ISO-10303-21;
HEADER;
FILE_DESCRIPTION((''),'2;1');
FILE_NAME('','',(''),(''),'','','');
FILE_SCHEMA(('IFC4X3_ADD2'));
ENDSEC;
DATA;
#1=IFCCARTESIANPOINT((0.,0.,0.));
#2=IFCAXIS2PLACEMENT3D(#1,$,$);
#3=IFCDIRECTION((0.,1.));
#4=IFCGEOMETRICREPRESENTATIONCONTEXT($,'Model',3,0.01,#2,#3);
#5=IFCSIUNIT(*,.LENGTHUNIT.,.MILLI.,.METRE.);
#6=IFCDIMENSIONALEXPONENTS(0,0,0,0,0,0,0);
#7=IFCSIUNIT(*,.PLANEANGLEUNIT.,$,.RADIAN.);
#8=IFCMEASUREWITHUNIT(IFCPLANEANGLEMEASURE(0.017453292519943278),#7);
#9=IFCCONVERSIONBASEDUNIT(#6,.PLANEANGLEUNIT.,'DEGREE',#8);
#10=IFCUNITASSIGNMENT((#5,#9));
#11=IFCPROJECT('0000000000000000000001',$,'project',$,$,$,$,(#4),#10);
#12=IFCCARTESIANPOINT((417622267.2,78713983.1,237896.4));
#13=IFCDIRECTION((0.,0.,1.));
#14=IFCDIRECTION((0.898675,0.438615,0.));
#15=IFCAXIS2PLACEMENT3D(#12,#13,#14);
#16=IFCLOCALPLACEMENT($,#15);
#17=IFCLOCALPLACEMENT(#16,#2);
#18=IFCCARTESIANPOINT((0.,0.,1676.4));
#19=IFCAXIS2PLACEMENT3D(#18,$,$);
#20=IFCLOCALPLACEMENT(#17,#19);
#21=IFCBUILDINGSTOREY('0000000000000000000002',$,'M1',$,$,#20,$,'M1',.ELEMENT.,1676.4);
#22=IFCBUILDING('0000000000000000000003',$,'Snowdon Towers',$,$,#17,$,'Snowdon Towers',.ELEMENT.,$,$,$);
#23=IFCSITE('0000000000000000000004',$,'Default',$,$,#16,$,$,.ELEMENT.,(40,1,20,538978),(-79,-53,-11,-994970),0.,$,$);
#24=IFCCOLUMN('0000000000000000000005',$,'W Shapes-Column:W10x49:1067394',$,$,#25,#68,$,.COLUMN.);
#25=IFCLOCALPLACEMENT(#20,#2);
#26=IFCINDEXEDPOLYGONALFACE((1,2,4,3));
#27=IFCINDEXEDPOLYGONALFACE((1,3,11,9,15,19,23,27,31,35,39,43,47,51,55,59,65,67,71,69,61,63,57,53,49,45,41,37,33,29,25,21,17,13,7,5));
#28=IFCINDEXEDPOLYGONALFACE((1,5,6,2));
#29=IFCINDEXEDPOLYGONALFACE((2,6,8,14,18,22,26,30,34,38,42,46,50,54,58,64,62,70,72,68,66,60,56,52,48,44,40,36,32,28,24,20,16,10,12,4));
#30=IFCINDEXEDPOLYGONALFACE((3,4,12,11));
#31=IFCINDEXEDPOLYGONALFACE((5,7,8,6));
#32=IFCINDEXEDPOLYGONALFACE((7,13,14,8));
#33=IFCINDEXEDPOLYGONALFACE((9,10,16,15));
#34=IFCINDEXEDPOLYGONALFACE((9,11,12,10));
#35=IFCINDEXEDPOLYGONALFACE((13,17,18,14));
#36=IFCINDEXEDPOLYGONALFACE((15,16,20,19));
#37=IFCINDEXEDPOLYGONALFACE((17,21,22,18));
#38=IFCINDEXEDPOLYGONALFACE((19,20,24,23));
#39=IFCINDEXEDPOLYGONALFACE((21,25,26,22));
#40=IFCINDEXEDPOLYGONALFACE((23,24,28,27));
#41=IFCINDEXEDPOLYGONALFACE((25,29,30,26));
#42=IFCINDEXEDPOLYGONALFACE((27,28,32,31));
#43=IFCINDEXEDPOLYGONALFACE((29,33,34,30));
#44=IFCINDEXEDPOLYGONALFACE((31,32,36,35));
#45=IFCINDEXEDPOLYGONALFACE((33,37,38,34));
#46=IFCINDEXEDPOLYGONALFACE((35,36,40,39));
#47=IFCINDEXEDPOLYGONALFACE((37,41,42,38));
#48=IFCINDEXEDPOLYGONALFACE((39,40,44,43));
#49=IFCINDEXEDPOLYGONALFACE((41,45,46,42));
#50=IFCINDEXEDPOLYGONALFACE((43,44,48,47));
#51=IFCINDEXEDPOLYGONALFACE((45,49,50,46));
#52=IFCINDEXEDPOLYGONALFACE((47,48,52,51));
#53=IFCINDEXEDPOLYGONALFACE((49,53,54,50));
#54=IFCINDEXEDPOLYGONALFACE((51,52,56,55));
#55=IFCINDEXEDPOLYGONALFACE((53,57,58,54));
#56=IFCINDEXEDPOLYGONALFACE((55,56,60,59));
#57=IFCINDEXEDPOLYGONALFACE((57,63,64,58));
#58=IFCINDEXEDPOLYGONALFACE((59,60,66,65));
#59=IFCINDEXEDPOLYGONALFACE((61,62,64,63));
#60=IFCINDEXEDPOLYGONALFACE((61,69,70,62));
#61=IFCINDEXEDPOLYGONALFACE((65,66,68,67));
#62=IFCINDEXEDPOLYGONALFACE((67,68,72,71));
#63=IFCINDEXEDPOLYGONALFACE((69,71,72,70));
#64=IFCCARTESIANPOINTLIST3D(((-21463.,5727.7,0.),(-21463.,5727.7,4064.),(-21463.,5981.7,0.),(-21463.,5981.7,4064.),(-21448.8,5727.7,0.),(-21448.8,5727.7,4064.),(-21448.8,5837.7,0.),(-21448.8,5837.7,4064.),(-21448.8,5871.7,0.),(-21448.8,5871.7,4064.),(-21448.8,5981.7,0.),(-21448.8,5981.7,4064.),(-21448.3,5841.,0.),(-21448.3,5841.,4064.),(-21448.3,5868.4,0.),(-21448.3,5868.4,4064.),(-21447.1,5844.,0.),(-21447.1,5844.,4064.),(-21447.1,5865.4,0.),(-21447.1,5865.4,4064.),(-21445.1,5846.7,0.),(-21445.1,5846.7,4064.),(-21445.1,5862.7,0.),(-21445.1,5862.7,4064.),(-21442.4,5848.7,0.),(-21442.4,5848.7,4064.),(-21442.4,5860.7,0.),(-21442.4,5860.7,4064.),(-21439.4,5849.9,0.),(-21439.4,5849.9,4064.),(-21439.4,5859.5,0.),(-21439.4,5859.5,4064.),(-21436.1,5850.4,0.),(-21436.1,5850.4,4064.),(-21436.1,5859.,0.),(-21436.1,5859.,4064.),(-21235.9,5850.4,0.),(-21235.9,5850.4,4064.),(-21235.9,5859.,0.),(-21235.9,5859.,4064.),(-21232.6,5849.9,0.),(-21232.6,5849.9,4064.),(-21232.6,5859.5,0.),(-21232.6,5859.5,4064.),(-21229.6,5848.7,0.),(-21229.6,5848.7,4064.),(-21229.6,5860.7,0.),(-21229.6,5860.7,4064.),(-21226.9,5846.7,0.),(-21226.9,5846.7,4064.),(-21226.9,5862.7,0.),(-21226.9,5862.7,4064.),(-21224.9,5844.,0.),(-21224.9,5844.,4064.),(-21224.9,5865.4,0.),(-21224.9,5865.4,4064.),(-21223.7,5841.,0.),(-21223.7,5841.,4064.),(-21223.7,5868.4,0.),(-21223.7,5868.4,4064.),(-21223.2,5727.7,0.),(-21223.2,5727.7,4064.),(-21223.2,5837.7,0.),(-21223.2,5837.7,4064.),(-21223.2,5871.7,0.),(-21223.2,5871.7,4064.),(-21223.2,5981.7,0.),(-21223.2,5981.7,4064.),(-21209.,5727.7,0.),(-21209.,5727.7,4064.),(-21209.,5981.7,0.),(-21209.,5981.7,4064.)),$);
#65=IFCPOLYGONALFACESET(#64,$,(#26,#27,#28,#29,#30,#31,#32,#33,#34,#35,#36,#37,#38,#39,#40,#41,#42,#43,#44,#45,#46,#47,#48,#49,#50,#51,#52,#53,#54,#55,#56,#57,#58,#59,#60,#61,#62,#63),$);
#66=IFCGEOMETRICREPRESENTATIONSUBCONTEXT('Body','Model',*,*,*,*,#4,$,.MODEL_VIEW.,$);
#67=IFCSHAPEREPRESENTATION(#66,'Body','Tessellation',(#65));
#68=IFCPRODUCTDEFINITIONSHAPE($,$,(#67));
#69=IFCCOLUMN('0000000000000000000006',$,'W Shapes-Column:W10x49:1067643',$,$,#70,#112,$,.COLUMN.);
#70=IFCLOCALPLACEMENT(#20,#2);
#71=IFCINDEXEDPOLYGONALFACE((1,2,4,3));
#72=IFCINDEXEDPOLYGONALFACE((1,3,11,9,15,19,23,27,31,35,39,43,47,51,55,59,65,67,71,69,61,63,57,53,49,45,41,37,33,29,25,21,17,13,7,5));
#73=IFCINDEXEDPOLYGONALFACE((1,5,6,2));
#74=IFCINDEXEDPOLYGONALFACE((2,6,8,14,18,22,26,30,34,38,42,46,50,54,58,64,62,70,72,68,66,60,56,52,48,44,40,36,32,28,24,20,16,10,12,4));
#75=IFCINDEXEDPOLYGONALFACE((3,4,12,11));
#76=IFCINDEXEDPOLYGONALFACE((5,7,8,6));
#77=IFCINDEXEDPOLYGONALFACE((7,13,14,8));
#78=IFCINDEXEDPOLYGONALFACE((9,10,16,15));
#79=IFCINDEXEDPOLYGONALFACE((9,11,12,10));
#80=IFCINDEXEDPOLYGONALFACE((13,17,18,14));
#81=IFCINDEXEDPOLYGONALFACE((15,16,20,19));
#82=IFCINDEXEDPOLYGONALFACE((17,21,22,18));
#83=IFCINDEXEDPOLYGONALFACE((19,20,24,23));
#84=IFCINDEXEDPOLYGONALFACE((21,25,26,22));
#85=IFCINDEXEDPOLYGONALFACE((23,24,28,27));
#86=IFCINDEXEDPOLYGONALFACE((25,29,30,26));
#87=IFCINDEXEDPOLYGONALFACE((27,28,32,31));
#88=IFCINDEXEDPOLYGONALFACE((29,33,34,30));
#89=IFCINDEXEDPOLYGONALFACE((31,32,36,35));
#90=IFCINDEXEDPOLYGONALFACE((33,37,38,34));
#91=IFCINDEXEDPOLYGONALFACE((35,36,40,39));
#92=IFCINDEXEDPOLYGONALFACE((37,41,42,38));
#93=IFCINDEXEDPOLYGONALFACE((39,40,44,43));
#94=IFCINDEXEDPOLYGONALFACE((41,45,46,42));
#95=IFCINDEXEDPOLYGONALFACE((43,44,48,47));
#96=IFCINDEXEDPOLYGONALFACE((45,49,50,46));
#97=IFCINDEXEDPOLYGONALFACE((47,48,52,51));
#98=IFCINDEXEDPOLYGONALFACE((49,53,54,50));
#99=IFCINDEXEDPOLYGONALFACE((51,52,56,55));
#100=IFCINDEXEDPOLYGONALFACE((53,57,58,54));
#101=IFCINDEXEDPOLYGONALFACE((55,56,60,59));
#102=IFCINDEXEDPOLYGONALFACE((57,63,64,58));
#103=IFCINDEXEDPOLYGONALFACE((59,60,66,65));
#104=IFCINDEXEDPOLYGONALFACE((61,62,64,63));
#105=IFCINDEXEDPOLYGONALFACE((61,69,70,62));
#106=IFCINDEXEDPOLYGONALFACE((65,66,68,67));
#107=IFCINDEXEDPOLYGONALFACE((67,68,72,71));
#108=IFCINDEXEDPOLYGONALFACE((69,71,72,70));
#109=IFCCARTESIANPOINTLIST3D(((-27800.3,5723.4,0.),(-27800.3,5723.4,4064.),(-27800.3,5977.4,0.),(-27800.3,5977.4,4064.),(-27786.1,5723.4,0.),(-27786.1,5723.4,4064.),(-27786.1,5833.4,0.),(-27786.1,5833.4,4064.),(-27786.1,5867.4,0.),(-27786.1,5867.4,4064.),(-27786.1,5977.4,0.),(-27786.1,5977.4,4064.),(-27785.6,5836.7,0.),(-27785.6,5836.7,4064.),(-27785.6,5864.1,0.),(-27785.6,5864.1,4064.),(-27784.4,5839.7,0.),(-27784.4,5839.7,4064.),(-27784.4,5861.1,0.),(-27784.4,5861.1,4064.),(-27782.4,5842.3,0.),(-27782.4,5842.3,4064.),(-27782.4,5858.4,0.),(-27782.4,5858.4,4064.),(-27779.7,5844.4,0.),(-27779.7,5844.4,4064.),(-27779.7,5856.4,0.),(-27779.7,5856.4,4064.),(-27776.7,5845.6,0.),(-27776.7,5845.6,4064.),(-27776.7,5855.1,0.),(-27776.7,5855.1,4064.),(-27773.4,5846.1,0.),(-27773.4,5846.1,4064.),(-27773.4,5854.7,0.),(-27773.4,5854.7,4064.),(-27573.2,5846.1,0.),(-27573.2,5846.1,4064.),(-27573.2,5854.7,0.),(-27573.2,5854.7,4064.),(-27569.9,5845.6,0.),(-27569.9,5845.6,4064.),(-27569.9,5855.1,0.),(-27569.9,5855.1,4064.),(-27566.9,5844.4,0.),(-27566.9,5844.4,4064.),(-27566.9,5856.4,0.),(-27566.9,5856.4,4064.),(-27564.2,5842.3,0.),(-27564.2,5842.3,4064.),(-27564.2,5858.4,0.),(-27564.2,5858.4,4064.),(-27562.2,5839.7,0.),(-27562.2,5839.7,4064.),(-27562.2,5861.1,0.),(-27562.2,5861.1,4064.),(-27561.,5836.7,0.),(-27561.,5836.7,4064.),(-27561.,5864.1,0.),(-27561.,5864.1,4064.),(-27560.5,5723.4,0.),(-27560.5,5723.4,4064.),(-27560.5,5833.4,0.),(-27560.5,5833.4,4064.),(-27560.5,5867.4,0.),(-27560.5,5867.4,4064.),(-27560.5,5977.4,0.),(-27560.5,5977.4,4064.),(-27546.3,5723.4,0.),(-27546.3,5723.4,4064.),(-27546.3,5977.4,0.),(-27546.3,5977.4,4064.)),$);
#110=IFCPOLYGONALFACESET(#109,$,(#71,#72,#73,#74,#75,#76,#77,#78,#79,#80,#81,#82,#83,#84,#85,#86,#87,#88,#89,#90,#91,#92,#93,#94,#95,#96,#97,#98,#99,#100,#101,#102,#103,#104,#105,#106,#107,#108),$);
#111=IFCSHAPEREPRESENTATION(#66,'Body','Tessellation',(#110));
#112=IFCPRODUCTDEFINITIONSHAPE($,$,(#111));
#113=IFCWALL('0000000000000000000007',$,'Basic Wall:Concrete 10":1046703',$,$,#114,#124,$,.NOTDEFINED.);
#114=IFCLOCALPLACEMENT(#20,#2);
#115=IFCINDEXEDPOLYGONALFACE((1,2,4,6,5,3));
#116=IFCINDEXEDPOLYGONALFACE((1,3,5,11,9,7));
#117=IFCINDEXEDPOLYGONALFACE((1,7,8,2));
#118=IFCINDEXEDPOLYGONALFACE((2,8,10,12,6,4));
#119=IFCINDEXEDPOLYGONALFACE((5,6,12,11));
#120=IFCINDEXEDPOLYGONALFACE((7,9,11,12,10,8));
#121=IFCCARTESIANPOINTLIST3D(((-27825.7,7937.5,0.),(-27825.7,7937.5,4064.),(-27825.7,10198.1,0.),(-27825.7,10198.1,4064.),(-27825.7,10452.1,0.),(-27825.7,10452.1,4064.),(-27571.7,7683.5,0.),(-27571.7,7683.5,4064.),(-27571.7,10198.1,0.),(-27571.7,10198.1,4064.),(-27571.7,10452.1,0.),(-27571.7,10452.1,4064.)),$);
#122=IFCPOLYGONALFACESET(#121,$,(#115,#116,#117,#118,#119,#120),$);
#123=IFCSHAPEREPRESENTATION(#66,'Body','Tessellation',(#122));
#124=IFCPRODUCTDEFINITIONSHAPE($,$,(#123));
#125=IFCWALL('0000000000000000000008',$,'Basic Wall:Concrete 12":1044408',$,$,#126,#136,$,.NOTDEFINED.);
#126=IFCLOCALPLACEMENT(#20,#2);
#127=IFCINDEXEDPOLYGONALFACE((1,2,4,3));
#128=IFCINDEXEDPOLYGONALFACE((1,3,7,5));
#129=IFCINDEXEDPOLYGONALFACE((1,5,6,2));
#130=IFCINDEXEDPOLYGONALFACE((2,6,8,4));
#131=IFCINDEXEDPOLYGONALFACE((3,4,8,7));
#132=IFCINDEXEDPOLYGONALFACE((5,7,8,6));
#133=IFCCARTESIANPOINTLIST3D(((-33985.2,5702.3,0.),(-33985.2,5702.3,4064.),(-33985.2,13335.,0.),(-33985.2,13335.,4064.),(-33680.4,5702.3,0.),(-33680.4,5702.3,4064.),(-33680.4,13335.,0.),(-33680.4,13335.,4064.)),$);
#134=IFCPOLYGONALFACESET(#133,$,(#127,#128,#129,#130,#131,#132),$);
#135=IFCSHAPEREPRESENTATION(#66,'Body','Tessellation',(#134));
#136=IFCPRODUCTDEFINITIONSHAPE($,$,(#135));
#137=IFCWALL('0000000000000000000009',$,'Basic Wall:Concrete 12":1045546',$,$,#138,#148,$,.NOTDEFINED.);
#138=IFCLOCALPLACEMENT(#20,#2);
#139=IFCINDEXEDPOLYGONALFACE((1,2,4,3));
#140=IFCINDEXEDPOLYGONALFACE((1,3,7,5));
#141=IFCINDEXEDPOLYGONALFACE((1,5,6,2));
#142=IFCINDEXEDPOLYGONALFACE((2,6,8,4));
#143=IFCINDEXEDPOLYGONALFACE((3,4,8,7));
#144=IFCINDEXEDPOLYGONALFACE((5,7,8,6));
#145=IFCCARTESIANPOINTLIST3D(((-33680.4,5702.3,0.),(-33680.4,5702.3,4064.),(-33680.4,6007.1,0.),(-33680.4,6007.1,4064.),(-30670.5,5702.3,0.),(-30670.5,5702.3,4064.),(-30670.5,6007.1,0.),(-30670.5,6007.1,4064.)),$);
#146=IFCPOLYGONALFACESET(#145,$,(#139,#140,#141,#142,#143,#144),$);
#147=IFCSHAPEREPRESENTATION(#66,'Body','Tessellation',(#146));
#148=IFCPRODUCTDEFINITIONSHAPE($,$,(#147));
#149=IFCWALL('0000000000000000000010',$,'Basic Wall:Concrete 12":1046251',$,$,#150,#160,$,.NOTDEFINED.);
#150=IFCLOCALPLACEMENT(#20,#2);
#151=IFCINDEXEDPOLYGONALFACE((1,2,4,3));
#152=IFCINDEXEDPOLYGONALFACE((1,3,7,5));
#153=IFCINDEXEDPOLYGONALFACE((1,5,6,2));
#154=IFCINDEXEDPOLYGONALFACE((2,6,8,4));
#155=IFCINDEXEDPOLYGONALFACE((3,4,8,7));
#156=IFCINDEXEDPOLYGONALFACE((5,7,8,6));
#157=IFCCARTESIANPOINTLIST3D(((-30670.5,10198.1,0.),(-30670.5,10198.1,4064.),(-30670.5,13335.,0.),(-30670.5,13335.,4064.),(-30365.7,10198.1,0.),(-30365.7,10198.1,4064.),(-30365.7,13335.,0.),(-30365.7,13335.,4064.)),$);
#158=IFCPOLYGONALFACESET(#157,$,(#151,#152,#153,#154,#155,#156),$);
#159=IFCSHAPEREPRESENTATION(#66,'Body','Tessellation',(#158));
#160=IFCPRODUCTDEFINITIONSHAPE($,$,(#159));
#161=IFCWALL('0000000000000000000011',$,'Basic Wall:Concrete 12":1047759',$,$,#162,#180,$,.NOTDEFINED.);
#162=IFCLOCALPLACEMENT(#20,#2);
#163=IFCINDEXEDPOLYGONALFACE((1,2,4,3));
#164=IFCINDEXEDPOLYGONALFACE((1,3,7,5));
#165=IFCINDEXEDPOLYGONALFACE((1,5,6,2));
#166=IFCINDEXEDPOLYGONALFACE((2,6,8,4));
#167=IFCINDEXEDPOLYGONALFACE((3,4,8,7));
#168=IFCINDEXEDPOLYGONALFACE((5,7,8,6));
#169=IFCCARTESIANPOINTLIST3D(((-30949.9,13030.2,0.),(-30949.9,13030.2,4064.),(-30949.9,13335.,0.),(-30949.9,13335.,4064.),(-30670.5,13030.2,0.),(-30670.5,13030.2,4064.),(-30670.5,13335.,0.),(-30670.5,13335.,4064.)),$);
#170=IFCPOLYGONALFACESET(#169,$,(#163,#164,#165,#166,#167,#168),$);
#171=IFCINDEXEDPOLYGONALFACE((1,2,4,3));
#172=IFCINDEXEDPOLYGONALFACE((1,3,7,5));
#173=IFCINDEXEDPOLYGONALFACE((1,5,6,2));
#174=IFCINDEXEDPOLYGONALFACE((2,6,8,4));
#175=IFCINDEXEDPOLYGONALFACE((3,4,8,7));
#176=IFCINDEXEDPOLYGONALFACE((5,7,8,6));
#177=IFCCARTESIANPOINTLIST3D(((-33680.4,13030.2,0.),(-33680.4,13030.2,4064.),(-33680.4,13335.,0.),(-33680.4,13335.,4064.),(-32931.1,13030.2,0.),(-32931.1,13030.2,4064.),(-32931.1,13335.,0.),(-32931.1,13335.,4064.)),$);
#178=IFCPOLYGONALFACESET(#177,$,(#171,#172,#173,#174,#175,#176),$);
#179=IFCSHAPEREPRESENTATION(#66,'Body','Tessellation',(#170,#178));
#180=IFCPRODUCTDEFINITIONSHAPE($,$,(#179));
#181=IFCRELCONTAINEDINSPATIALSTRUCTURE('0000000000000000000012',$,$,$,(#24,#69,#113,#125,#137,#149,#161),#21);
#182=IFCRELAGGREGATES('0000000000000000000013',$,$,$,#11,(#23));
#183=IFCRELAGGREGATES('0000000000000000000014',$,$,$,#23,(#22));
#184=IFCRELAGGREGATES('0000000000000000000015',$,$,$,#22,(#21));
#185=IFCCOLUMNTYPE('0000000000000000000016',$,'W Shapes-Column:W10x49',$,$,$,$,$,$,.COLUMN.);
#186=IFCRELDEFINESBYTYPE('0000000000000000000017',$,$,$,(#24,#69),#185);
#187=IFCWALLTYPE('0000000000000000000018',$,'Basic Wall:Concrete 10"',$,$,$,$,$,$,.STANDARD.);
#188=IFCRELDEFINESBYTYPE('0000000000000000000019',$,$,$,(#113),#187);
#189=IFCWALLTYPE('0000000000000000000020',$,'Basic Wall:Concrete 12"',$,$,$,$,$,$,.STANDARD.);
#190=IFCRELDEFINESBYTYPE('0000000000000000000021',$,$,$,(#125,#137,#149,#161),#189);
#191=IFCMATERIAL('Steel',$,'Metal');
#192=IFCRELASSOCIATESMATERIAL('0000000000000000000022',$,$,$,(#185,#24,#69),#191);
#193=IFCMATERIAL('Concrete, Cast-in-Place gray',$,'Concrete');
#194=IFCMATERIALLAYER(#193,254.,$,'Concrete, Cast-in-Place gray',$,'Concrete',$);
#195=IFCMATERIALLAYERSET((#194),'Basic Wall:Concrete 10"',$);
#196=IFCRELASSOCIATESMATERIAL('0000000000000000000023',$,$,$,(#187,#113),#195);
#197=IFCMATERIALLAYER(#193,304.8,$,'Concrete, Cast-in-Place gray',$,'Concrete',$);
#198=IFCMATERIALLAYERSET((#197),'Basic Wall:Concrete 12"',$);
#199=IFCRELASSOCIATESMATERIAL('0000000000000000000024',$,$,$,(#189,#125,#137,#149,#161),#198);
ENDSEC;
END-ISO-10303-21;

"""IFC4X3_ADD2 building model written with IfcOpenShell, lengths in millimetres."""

from ifc_helpers import new_model, entity, si_unit, converted_unit, direction, frame, frame_2d, origin, place, context, subcontext, project, spatial, polyline, rectangle, i_section, outline, extrude, source, transform, mapped, material, layer, layer_set, material_profile, profile_set, profile_usage, type_object, type_shapes, element, save


model = new_model("IFC4X3_ADD2")

# Units and contexts
model_context = context("Model", 3, precision=0.01, world=origin(), true_north=direction((0.0, 1.0)))
body_context = subcontext(model_context, "Body", "Model", "MODEL_VIEW")
ifc_project = project(units=[si_unit("LENGTHUNIT", "METRE", prefix="MILLI"), converted_unit("PLANEANGLEUNIT", "DEGREE", entity("IfcPlaneAngleMeasure", 0.017453292519943278), si_unit("PLANEANGLEUNIT", "RADIAN"), dimensions=[0, 0, 0, 0, 0, 0, 0])], contexts=[model_context])

# Site, building, storey
site_placement = place(None, frame((417622267.2, 78713983.1, 237896.4), z_axis=(0.0, 0.0, 1.0), x_axis=(0.898675, 0.438615, 0.0)))
site = spatial("IfcSite", under=ifc_project, at=site_placement, Name="Default", CompositionType="ELEMENT", RefLatitude=(40, 1, 20, 538978), RefLongitude=(-79, -53, -11, -994970), RefElevation=0.0)
building_placement = place(site_placement, origin())
building = spatial("IfcBuilding", under=site, at=building_placement, Name="Snowdon Towers", LongName="Snowdon Towers", CompositionType="ELEMENT")
storey_placement = place(building_placement, frame((0.0, 0.0, 1676.4)))
storey = spatial("IfcBuildingStorey", under=building, at=storey_placement, Name="M1", LongName="M1", CompositionType="ELEMENT", Elevation=1676.4)

# Columns
ifc_material_1 = material(Name="Steel", Category="Metal")
ifc_material_profile_1 = material_profile(ifc_material_1, i_section(OverallWidth=254.0, OverallDepth=254.0, WebThickness=8.6, FlangeThickness=14.2, FilletRadius=12.7, at=frame_2d((0.0, 0.0), x_axis=(1.0, 0.0))), Name="W10x49")
ifc_profile_set_1 = profile_set([ifc_material_profile_1], Name="W10x49")
ifc_profile_usage_1 = profile_usage(ifc_profile_set_1)
column_type_1 = type_object("IfcColumnType", Name="W Shapes-Column:W10x49", PredefinedType="COLUMN", material=ifc_profile_set_1)
shared_shape_1 = source(origin(), body_context, "Body", "SweptSolid", [
    extrude(i_section(OverallWidth=254.0, OverallDepth=254.0, WebThickness=8.6, FlangeThickness=14.2, FilletRadius=12.7, at=frame_2d((0.0, 0.0), x_axis=(1.0, 0.0))), frame((0.0, 0.0, 1676.4), z_axis=(0.0, 0.0, 1.0), x_axis=(-1.0, 0.0, 0.0)), (0.0, 0.0, 1.0), 4064.0),
])
type_shapes(column_type_1, [shared_shape_1])
for number, where, z_axis, x_axis, name in (
    (1, (-21336.0, 5854.7, -1676.4), (0.0, 0.0, 1.0), (0.0, 1.0, 0.0), "W Shapes-Column:W10x49:1067394"),
    (2, (-27673.3, 5850.4, -1676.4), (0.0, 0.0, 1.0), (0.0, 1.0, 0.0), "W Shapes-Column:W10x49:1067643"),
):
    element("IfcColumn", number, at=place(storey_placement, frame(where, z_axis=z_axis, x_axis=x_axis)), inside=storey, type_object=column_type_1, material=ifc_profile_usage_1, Name=name, PredefinedType="COLUMN", context=body_context, shape_type="MappedRepresentation", body=[
        mapped(shared_shape_1, transform((0.0, 0.0, 0.0), scale=1.0)),
    ])

# Walls
ifc_material_2 = material(Name="Concrete, Cast-in-Place gray", Category="Concrete")
ifc_layer_1 = layer(ifc_material_2, 254.0, Name="Concrete, Cast-in-Place gray", Category="Concrete")
ifc_layer_set_1 = layer_set([ifc_layer_1], Name="Basic Wall:Concrete 10\"")
wall_type_1 = type_object("IfcWallType", Name="Basic Wall:Concrete 10\"", PredefinedType="STANDARD", material=ifc_layer_set_1)
wall_1_placement = place(storey_placement, frame((-27698.7, 10452.1, 0.0), z_axis=(0.0, 0.0, 1.0), x_axis=(0.0, -1.0, 0.0)))
element("IfcWall", 3, at=wall_1_placement, inside=storey, type_object=wall_type_1, material=ifc_layer_set_1, Name="Basic Wall:Concrete 10\":1046703", PredefinedType="NOTDEFINED", context=body_context, shape_type="SweptSolid", body=[
    extrude(outline(polyline([(2514.6, -127.0), (2768.6, 127.0), (254.0, 127.0), (0.0, 127.0), (0.0, -127.0), (254.0, -127.0), (2514.6, -127.0)])), origin(), (0.0, 0.0, 1.0), 4064.0),
])
ifc_layer_2 = layer(ifc_material_2, 304.8, Name="Concrete, Cast-in-Place gray", Category="Concrete")
ifc_layer_set_2 = layer_set([ifc_layer_2], Name="Basic Wall:Concrete 12\"")
wall_type_2 = type_object("IfcWallType", Name="Basic Wall:Concrete 12\"", PredefinedType="STANDARD", material=ifc_layer_set_2)
wall_2_placement = place(storey_placement, frame((-33832.8, 13335.0, 0.0), z_axis=(0.0, 0.0, 1.0), x_axis=(0.0, -1.0, 0.0)))
element("IfcWall", 4, at=wall_2_placement, inside=storey, type_object=wall_type_2, material=ifc_layer_set_2, Name="Basic Wall:Concrete 12\":1044408", PredefinedType="NOTDEFINED", context=body_context, shape_type="SweptSolid", body=[
    extrude(rectangle(XDim=7632.7, YDim=304.8, at=frame_2d((3816.4, 0.0), x_axis=(-1.0, 0.0))), origin(), (0.0, 0.0, 1.0), 4064.0),
])
wall_3_placement = place(storey_placement, frame((-30670.5, 5854.7, 0.0), z_axis=(0.0, 0.0, 1.0), x_axis=(-1.0, 0.0, 0.0)))
element("IfcWall", 5, at=wall_3_placement, inside=storey, type_object=wall_type_2, material=ifc_layer_set_2, Name="Basic Wall:Concrete 12\":1045546", PredefinedType="NOTDEFINED", context=body_context, shape_type="SweptSolid", body=[
    extrude(rectangle(XDim=3009.9, YDim=304.8, at=frame_2d((1505.0, 0.0), x_axis=(-1.0, 0.0))), origin(), (0.0, 0.0, 1.0), 4064.0),
])
wall_4_placement = place(storey_placement, frame((-30518.1, 10198.1, 0.0), z_axis=(0.0, 0.0, 1.0), x_axis=(0.0, 1.0, 0.0)))
element("IfcWall", 6, at=wall_4_placement, inside=storey, type_object=wall_type_2, material=ifc_layer_set_2, Name="Basic Wall:Concrete 12\":1046251", PredefinedType="NOTDEFINED", context=body_context, shape_type="SweptSolid", body=[
    extrude(rectangle(XDim=3136.9, YDim=304.8, at=frame_2d((1568.5, 0.0), x_axis=(-1.0, 0.0))), origin(), (0.0, 0.0, 1.0), 4064.0),
])
wall_5_placement = place(storey_placement, frame((-30670.5, 13182.6, 0.0), z_axis=(0.0, 0.0, 1.0), x_axis=(-1.0, 0.0, 0.0)))
element("IfcWall", 7, at=wall_5_placement, inside=storey, type_object=wall_type_2, material=ifc_layer_set_2, Name="Basic Wall:Concrete 12\":1047759", PredefinedType="NOTDEFINED", context=body_context, shape_type="SweptSolid", body=[
    extrude(rectangle(XDim=304.8, YDim=279.4, at=frame_2d((0.0, 0.0), x_axis=(1.0, 0.0))), frame((139.7, 0.0, 0.0), z_axis=(0.0, 0.0, 1.0), x_axis=(0.0, 1.0, 0.0)), (0.0, 0.0, 1.0), 4064.0),
    extrude(rectangle(XDim=304.8, YDim=749.3, at=frame_2d((0.0, 0.0), x_axis=(1.0, 0.0))), frame((2635.3, 0.0, 0.0), z_axis=(0.0, 0.0, 1.0), x_axis=(0.0, 1.0, 0.0)), (0.0, 0.0, 1.0), 4064.0),
])

save(model, "model.ifc")
